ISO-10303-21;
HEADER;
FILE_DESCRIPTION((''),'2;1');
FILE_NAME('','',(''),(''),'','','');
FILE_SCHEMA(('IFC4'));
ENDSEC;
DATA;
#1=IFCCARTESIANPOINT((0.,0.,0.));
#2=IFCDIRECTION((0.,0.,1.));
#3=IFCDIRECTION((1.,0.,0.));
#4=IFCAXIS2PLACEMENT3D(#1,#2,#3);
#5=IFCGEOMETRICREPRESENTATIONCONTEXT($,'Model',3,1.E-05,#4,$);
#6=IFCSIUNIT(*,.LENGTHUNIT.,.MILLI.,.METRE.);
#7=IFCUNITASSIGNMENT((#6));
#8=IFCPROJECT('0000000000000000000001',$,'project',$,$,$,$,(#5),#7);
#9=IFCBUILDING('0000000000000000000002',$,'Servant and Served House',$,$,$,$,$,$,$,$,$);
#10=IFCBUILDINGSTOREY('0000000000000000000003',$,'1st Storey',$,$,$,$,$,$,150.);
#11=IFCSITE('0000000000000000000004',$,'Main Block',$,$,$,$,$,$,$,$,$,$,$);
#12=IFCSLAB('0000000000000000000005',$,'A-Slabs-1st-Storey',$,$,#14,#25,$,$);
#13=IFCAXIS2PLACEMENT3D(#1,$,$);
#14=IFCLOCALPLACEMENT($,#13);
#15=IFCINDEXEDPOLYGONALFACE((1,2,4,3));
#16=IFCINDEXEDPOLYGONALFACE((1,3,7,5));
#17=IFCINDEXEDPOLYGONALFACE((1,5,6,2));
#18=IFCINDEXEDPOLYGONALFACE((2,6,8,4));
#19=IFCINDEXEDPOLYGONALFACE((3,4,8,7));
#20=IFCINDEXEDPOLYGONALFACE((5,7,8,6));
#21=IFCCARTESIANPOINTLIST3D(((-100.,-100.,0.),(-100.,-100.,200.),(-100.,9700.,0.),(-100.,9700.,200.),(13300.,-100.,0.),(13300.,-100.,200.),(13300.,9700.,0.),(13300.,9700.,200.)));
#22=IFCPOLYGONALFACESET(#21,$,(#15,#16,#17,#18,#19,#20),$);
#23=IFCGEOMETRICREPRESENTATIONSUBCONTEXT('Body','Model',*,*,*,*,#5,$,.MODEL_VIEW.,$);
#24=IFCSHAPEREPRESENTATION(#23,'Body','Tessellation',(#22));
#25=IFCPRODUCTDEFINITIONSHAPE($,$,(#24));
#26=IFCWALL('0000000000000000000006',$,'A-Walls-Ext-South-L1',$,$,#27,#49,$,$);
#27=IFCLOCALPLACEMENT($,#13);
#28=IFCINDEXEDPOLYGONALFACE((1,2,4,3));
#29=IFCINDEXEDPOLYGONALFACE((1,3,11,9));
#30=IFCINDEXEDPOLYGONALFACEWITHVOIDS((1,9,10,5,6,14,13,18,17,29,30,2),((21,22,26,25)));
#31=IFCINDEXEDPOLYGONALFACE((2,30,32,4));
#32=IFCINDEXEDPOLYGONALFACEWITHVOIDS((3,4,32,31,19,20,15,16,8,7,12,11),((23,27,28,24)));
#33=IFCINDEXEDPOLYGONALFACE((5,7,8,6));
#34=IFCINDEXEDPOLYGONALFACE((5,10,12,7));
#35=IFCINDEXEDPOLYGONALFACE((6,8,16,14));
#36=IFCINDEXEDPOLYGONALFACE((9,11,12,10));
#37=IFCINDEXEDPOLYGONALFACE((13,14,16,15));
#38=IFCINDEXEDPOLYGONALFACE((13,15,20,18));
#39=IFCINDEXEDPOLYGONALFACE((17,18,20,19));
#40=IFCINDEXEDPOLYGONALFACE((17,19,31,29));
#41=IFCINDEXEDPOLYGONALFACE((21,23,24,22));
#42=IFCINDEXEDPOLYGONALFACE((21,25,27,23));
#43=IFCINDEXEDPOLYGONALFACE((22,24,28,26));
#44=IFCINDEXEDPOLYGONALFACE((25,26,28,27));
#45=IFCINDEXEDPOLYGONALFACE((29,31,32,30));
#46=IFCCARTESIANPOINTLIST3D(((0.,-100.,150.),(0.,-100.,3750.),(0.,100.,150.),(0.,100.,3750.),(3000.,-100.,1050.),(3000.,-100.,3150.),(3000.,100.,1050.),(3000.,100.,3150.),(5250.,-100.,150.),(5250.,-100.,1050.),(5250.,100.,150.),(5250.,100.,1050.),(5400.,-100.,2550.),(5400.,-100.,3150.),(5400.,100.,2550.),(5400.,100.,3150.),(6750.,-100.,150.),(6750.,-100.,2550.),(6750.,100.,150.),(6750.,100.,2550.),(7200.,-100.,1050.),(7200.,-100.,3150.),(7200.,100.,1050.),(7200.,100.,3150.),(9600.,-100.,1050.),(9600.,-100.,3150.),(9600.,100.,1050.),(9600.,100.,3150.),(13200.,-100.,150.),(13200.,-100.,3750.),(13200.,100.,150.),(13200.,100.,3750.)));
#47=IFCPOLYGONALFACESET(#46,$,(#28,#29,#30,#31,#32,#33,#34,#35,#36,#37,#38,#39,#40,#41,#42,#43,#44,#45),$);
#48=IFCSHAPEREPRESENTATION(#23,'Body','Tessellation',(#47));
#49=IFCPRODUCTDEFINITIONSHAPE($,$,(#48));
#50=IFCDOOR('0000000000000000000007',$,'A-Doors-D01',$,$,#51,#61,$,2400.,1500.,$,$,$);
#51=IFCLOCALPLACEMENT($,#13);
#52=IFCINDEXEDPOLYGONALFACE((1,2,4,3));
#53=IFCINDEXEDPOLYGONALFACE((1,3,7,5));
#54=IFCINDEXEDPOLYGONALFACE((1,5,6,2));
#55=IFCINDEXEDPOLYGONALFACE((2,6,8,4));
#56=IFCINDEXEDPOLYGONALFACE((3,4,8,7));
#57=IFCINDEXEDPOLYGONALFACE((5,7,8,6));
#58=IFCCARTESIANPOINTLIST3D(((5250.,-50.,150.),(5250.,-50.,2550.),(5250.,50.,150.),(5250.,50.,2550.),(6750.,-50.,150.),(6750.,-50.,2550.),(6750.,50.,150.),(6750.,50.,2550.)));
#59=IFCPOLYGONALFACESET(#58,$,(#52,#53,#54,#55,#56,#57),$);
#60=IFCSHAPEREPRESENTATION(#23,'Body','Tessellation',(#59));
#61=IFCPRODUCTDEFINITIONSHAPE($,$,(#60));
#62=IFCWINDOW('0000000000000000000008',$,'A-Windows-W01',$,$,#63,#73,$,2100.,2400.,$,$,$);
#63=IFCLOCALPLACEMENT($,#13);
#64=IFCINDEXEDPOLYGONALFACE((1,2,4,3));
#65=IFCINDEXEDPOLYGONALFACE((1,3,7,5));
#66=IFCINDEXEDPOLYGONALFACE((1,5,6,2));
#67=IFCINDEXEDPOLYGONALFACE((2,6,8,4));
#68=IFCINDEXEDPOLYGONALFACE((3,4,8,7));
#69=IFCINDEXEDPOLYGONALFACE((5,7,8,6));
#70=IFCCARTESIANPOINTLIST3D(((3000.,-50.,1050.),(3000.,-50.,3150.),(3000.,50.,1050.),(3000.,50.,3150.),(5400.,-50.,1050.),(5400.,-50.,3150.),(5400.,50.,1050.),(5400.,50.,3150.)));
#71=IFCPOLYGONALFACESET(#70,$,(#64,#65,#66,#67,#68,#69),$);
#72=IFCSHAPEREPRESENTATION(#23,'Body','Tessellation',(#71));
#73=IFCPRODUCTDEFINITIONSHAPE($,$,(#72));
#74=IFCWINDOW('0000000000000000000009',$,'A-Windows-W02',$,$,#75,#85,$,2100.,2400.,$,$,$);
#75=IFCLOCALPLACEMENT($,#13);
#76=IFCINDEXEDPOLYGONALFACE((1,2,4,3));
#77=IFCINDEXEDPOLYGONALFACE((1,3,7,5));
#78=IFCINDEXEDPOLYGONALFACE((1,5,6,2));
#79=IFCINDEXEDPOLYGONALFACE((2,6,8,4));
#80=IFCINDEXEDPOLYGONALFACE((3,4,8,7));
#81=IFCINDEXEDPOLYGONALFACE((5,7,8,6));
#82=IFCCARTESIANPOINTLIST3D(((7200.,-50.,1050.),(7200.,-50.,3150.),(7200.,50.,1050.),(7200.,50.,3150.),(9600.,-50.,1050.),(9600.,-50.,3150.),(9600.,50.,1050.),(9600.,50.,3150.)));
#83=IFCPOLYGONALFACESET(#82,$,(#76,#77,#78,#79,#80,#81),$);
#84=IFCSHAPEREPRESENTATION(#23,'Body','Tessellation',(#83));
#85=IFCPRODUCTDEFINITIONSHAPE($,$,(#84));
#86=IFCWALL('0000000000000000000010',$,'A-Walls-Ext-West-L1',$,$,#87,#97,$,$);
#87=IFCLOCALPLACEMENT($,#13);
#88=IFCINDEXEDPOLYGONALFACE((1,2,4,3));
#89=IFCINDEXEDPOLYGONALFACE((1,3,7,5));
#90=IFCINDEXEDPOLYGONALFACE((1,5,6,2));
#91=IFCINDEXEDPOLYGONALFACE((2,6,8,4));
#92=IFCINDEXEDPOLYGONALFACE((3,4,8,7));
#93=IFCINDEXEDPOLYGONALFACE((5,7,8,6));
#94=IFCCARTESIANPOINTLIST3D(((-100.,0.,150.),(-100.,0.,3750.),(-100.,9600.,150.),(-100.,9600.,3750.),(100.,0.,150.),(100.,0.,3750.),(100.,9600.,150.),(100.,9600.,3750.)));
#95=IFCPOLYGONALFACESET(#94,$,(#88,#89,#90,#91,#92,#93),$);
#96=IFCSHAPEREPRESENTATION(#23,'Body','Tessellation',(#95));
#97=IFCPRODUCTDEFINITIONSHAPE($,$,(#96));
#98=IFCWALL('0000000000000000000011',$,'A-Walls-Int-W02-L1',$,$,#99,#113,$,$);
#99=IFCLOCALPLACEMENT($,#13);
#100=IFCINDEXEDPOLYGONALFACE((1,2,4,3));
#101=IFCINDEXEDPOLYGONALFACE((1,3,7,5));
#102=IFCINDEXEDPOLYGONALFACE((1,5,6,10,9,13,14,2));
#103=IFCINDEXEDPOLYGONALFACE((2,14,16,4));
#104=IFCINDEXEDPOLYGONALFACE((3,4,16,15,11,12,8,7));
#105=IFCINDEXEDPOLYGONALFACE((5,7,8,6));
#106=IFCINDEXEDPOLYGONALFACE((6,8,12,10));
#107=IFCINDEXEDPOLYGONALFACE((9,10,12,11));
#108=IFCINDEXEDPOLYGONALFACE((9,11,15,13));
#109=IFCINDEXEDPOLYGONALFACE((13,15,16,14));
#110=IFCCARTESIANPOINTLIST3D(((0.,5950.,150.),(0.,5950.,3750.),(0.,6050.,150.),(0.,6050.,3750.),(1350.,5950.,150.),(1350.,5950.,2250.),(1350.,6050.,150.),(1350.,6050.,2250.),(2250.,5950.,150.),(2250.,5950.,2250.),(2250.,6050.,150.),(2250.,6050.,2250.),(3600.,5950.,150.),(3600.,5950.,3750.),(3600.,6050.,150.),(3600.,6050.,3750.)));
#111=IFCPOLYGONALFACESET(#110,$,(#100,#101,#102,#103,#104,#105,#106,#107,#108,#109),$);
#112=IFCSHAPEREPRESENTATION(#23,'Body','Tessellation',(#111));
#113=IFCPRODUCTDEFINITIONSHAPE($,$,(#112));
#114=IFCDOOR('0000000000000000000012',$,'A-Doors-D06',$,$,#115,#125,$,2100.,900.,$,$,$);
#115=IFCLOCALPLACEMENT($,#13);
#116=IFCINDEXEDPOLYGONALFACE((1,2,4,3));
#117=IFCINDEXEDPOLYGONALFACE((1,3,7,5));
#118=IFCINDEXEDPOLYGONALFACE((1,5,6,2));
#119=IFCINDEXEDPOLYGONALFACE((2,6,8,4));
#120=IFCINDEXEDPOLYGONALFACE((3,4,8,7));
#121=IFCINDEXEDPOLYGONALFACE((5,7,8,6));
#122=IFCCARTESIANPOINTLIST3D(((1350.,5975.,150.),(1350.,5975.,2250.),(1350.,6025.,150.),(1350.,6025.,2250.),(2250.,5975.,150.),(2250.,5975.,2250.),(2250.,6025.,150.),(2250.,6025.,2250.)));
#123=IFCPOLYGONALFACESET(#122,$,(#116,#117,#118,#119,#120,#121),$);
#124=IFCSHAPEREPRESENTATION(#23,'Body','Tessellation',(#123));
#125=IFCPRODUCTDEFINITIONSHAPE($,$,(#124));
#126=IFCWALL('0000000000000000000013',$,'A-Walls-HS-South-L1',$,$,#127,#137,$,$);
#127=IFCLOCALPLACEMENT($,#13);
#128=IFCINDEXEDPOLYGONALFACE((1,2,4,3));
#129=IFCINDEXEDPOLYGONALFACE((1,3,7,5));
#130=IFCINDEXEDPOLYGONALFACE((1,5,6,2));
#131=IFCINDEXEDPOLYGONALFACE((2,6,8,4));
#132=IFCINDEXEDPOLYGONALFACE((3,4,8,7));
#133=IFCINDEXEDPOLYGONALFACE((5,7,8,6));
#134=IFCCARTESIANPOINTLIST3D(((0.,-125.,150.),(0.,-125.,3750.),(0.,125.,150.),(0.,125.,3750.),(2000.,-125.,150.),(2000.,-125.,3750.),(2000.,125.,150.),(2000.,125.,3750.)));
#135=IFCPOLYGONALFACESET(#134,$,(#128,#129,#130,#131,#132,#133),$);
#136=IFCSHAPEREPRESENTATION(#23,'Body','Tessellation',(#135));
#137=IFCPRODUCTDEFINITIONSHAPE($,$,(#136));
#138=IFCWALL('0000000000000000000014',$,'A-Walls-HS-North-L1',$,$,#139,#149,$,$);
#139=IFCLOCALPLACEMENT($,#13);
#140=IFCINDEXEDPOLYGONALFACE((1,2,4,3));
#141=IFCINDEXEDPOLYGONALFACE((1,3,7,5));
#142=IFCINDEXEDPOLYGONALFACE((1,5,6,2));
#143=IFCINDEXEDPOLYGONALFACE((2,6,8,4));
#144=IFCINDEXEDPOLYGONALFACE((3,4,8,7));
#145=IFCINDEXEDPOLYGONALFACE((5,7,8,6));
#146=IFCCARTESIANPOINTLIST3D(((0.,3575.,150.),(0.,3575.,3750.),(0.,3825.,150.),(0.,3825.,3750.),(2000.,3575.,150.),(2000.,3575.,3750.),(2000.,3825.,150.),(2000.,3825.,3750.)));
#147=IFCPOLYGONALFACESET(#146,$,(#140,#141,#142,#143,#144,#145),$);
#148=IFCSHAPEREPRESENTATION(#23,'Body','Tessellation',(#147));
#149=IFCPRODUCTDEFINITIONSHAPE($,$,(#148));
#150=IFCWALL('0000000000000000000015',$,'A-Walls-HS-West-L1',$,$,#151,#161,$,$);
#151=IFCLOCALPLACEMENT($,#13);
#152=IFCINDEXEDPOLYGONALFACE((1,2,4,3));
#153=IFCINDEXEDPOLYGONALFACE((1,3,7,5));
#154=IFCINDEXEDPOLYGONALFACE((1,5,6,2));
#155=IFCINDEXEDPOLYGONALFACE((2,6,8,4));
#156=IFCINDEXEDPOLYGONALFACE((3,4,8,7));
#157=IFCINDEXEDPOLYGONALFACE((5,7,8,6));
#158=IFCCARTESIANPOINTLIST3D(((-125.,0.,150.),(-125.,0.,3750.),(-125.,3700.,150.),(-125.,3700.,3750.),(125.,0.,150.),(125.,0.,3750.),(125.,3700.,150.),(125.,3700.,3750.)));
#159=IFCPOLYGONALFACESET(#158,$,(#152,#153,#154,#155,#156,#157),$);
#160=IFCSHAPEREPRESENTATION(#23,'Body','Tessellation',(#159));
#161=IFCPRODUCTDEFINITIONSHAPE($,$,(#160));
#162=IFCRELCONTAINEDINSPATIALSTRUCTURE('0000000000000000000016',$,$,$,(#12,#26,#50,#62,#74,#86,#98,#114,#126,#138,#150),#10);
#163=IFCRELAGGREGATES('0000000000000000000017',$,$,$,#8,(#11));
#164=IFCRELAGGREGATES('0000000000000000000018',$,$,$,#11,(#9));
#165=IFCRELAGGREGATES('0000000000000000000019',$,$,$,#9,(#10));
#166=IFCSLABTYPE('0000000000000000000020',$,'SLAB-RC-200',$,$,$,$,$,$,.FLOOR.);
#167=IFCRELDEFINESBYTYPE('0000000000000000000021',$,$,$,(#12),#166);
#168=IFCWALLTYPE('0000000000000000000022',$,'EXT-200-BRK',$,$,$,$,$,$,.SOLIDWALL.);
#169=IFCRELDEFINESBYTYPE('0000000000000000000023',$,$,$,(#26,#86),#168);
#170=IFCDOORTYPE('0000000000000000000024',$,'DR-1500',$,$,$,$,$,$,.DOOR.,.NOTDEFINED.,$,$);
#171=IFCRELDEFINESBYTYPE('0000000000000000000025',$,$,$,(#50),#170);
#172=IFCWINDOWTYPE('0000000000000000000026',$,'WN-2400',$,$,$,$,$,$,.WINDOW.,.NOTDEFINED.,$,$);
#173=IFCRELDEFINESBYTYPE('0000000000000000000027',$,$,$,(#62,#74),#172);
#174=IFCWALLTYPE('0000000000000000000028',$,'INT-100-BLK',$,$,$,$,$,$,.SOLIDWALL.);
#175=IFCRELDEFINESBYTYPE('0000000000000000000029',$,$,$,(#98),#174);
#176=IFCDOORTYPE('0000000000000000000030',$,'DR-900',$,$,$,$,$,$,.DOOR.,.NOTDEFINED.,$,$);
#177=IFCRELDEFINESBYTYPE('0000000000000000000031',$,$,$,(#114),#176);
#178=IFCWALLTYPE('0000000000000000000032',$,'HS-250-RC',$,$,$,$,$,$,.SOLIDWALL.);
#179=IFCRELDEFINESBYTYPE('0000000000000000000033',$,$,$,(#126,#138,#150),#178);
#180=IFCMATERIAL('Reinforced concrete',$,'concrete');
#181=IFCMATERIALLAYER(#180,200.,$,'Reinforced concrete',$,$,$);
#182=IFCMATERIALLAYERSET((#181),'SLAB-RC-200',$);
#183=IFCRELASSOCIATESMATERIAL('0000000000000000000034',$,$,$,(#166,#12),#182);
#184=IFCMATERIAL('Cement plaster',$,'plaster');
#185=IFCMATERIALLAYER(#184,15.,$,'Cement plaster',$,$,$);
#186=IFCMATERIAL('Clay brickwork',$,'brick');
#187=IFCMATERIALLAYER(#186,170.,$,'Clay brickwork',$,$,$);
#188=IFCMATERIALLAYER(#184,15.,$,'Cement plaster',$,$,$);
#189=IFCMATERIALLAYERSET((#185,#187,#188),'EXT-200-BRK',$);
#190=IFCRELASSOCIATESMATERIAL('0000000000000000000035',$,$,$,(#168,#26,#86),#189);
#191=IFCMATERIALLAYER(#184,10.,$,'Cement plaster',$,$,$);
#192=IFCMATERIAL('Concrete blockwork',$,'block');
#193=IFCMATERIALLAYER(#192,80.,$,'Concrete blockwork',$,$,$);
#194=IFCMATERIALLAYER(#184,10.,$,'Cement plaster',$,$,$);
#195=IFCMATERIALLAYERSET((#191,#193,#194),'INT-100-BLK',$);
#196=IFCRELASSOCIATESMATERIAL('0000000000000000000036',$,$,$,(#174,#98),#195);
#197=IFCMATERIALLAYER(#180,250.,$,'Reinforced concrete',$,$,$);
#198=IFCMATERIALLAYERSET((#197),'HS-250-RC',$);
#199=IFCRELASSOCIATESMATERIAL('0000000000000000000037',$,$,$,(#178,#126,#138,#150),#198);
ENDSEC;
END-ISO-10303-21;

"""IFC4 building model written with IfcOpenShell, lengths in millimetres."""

from ifc_helpers import new_model, si_unit, frame, origin_with_axes, place, context, subcontext, project, spatial, indexed_curve, outline, extrude, material, layer, layer_set, layer_usage, type_object, element, fill, save


model = new_model("IFC4")

# Units and contexts
model_context = context("Model", 3, precision=1e-05, world=origin_with_axes())
body_context = subcontext(model_context, "Body", "Model", "MODEL_VIEW")
ifc_project = project(units=[si_unit("LENGTHUNIT", "METRE", prefix="MILLI")], contexts=[model_context])

# Site, building, storey
site = spatial("IfcSite", under=ifc_project, Name="Main Block")
building = spatial("IfcBuilding", under=site, Name="Servant and Served House")
storey = spatial("IfcBuildingStorey", under=building, Name="1st Storey", Elevation=150.0)

# Slab
ifc_material_1 = material(Name="Reinforced concrete", Category="concrete")
ifc_layer_1 = layer(ifc_material_1, 200.0, Name="Reinforced concrete")
ifc_layer_set_1 = layer_set([ifc_layer_1], Name="SLAB-RC-200")
ifc_layer_usage_1 = layer_usage(ifc_layer_set_1, "AXIS3", "POSITIVE", 0.0)
slab_type = type_object("IfcSlabType", Name="SLAB-RC-200", PredefinedType="FLOOR", material=ifc_layer_set_1)
slab_placement = place(None, origin_with_axes())
element("IfcSlab", 1, at=slab_placement, inside=storey, type_object=slab_type, material=ifc_layer_usage_1, Name="A-Slabs-1st-Storey", context=body_context, shape_type="SweptSolid", body=[
    extrude(outline(indexed_curve([(-100.0, -100.0), (13300.0, -100.0), (13300.0, 9700.0), (-100.0, 9700.0)])), None, (0.0, 0.0, 1.0), 200.0),
])

# Wall, openings, door, windows
ifc_material_2 = material(Name="Cement plaster", Category="plaster")
ifc_layer_2 = layer(ifc_material_2, 15.0, Name="Cement plaster")
ifc_material_3 = material(Name="Clay brickwork", Category="brick")
ifc_layer_3 = layer(ifc_material_3, 170.0, Name="Clay brickwork")
ifc_layer_4 = layer(ifc_material_2, 15.0, Name="Cement plaster")
ifc_layer_set_2 = layer_set([ifc_layer_2, ifc_layer_3, ifc_layer_4], Name="EXT-200-BRK")
ifc_layer_usage_2 = layer_usage(ifc_layer_set_2, "AXIS2", "POSITIVE", 0.0)
wall_type_1 = type_object("IfcWallType", Name="EXT-200-BRK", PredefinedType="SOLIDWALL", material=ifc_layer_set_2)
wall_1_placement = place(None, frame((0.0, -100.0, 150.0), z_axis=(0.0, 0.0, 1.0), x_axis=(1.0, 0.0, 0.0)))
wall_1 = element("IfcWall", 2, at=wall_1_placement, inside=storey, type_object=wall_type_1, material=ifc_layer_usage_2, Name="A-Walls-Ext-South-L1", context=body_context, shape_type="SweptSolid", body=[
    extrude(outline(indexed_curve([(0.0, 0.0), (0.0, 200.0), (13200.0, 200.0), (13200.0, 0.0), (0.0, 0.0)], self_intersect=False)), origin_with_axes(), (0.0, 0.0, 1.0), 3600.0),
])
opening_1_placement = place(wall_1_placement, frame((6000.0, 100.0, 0.0), z_axis=(0.0, 0.0, 1.0), x_axis=(1.0, 0.0, 0.0)))
opening_1 = element("IfcOpeningElement", 3, at=opening_1_placement, cuts=wall_1, PredefinedType="OPENING", context=body_context, shape_type="SweptSolid", body=[
    extrude(outline(indexed_curve([(-750.0, -150.0), (750.0, -150.0), (750.0, 150.0), (-750.0, 150.0)])), None, (0.0, 0.0, 1.0), 2400.0),
])
opening_2_placement = place(wall_1_placement, frame((4200.0, 100.0, 900.0), z_axis=(0.0, 0.0, 1.0), x_axis=(1.0, 0.0, 0.0)))
opening_2 = element("IfcOpeningElement", 4, at=opening_2_placement, cuts=wall_1, PredefinedType="OPENING", context=body_context, shape_type="SweptSolid", body=[
    extrude(outline(indexed_curve([(-1200.0, -150.0), (1200.0, -150.0), (1200.0, 150.0), (-1200.0, 150.0)])), None, (0.0, 0.0, 1.0), 2100.0),
])
opening_3_placement = place(wall_1_placement, frame((8400.0, 100.0, 900.0), z_axis=(0.0, 0.0, 1.0), x_axis=(1.0, 0.0, 0.0)))
opening_3 = element("IfcOpeningElement", 5, at=opening_3_placement, cuts=wall_1, PredefinedType="OPENING", context=body_context, shape_type="SweptSolid", body=[
    extrude(outline(indexed_curve([(-1200.0, -150.0), (1200.0, -150.0), (1200.0, 150.0), (-1200.0, 150.0)])), None, (0.0, 0.0, 1.0), 2100.0),
])
door_type_1 = type_object("IfcDoorType", Name="DR-1500", OperationType="NOTDEFINED", PredefinedType="DOOR")
door_1_placement = place(None, frame((6000.0, 0.0, 150.0), z_axis=(0.0, 0.0, 1.0), x_axis=(1.0, 0.0, 0.0)))
door_1 = element("IfcDoor", 6, at=door_1_placement, inside=storey, type_object=door_type_1, Name="A-Doors-D01", OverallHeight=2400.0, OverallWidth=1500.0, context=body_context, shape_type="SweptSolid", body=[
    extrude(outline(indexed_curve([(-750.0, -50.0), (750.0, -50.0), (750.0, 50.0), (-750.0, 50.0)])), None, (0.0, 0.0, 1.0), 2400.0),
])
fill(opening_1, door_1)
window_type = type_object("IfcWindowType", Name="WN-2400", PartitioningType="NOTDEFINED", PredefinedType="WINDOW")
window_1_placement = place(None, frame((4200.0, 0.0, 1050.0), z_axis=(0.0, 0.0, 1.0), x_axis=(1.0, 0.0, 0.0)))
window_1 = element("IfcWindow", 7, at=window_1_placement, inside=storey, type_object=window_type, Name="A-Windows-W01", OverallHeight=2100.0, OverallWidth=2400.0, context=body_context, shape_type="SweptSolid", body=[
    extrude(outline(indexed_curve([(-1200.0, -50.0), (1200.0, -50.0), (1200.0, 50.0), (-1200.0, 50.0)])), None, (0.0, 0.0, 1.0), 2100.0),
])
fill(opening_2, window_1)
window_2_placement = place(None, frame((8400.0, 0.0, 1050.0), z_axis=(0.0, 0.0, 1.0), x_axis=(1.0, 0.0, 0.0)))
window_2 = element("IfcWindow", 8, at=window_2_placement, inside=storey, type_object=window_type, Name="A-Windows-W02", OverallHeight=2100.0, OverallWidth=2400.0, context=body_context, shape_type="SweptSolid", body=[
    extrude(outline(indexed_curve([(-1200.0, -50.0), (1200.0, -50.0), (1200.0, 50.0), (-1200.0, 50.0)])), None, (0.0, 0.0, 1.0), 2100.0),
])
fill(opening_3, window_2)

# Wall
ifc_layer_usage_3 = layer_usage(ifc_layer_set_2, "AXIS2", "POSITIVE", 0.0)
wall_2_placement = place(None, frame((-100.0, 9600.0, 150.0), z_axis=(0.0, 0.0, 1.0), x_axis=(0.0, -1.0, 0.0)))
element("IfcWall", 9, at=wall_2_placement, inside=storey, type_object=wall_type_1, material=ifc_layer_usage_3, Name="A-Walls-Ext-West-L1", context=body_context, shape_type="SweptSolid", body=[
    extrude(outline(indexed_curve([(0.0, 0.0), (0.0, 200.0), (9600.0, 200.0), (9600.0, 0.0), (0.0, 0.0)], self_intersect=False)), origin_with_axes(), (0.0, 0.0, 1.0), 3600.0),
])

# Wall, opening, door
ifc_layer_5 = layer(ifc_material_2, 10.0, Name="Cement plaster")
ifc_material_4 = material(Name="Concrete blockwork", Category="block")
ifc_layer_6 = layer(ifc_material_4, 80.0, Name="Concrete blockwork")
ifc_layer_7 = layer(ifc_material_2, 10.0, Name="Cement plaster")
ifc_layer_set_3 = layer_set([ifc_layer_5, ifc_layer_6, ifc_layer_7], Name="INT-100-BLK")
ifc_layer_usage_4 = layer_usage(ifc_layer_set_3, "AXIS2", "POSITIVE", 0.0)
wall_type_2 = type_object("IfcWallType", Name="INT-100-BLK", PredefinedType="SOLIDWALL", material=ifc_layer_set_3)
wall_3_placement = place(None, frame((0.0, 5950.0, 150.0), z_axis=(0.0, 0.0, 1.0), x_axis=(1.0, 0.0, 0.0)))
wall_3 = element("IfcWall", 10, at=wall_3_placement, inside=storey, type_object=wall_type_2, material=ifc_layer_usage_4, Name="A-Walls-Int-W02-L1", context=body_context, shape_type="SweptSolid", body=[
    extrude(outline(indexed_curve([(0.0, 0.0), (0.0, 100.0), (3600.0, 100.0), (3600.0, 0.0), (0.0, 0.0)], self_intersect=False)), origin_with_axes(), (0.0, 0.0, 1.0), 3600.0),
])
opening_4_placement = place(wall_3_placement, frame((1800.0, 50.0, 0.0), z_axis=(0.0, 0.0, 1.0), x_axis=(1.0, 0.0, 0.0)))
opening_4 = element("IfcOpeningElement", 11, at=opening_4_placement, cuts=wall_3, PredefinedType="OPENING", context=body_context, shape_type="SweptSolid", body=[
    extrude(outline(indexed_curve([(-450.0, -100.0), (450.0, -100.0), (450.0, 100.0), (-450.0, 100.0)])), None, (0.0, 0.0, 1.0), 2100.0),
])
door_type_2 = type_object("IfcDoorType", Name="DR-900", OperationType="NOTDEFINED", PredefinedType="DOOR")
door_2_placement = place(None, frame((1800.0, 6000.0, 150.0), z_axis=(0.0, 0.0, 1.0), x_axis=(1.0, 0.0, 0.0)))
door_2 = element("IfcDoor", 12, at=door_2_placement, inside=storey, type_object=door_type_2, Name="A-Doors-D06", OverallHeight=2100.0, OverallWidth=900.0, context=body_context, shape_type="SweptSolid", body=[
    extrude(outline(indexed_curve([(-450.0, -25.0), (450.0, -25.0), (450.0, 25.0), (-450.0, 25.0)])), None, (0.0, 0.0, 1.0), 2100.0),
])
fill(opening_4, door_2)

# Walls
ifc_layer_8 = layer(ifc_material_1, 250.0, Name="Reinforced concrete")
ifc_layer_set_4 = layer_set([ifc_layer_8], Name="HS-250-RC")
ifc_layer_usage_5 = layer_usage(ifc_layer_set_4, "AXIS2", "POSITIVE", 0.0)
wall_type_3 = type_object("IfcWallType", Name="HS-250-RC", PredefinedType="SOLIDWALL", material=ifc_layer_set_4)
wall_4_placement = place(None, frame((0.0, -125.0, 150.0), z_axis=(0.0, 0.0, 1.0), x_axis=(1.0, 0.0, 0.0)))
element("IfcWall", 13, at=wall_4_placement, inside=storey, type_object=wall_type_3, material=ifc_layer_usage_5, Name="A-Walls-HS-South-L1", context=body_context, shape_type="SweptSolid", body=[
    extrude(outline(indexed_curve([(0.0, 0.0), (0.0, 250.0), (2000.0, 250.0), (2000.0, 0.0), (0.0, 0.0)], self_intersect=False)), origin_with_axes(), (0.0, 0.0, 1.0), 3600.0),
])
ifc_layer_usage_6 = layer_usage(ifc_layer_set_4, "AXIS2", "POSITIVE", 0.0)
wall_5_placement = place(None, frame((2000.0, 3825.0, 150.0), z_axis=(0.0, 0.0, 1.0), x_axis=(-1.0, 0.0, 0.0)))
element("IfcWall", 14, at=wall_5_placement, inside=storey, type_object=wall_type_3, material=ifc_layer_usage_6, Name="A-Walls-HS-North-L1", context=body_context, shape_type="SweptSolid", body=[
    extrude(outline(indexed_curve([(0.0, 0.0), (0.0, 250.0), (2000.0, 250.0), (2000.0, 0.0), (0.0, 0.0)], self_intersect=False)), origin_with_axes(), (0.0, 0.0, 1.0), 3600.0),
])
ifc_layer_usage_7 = layer_usage(ifc_layer_set_4, "AXIS2", "POSITIVE", 0.0)
wall_6_placement = place(None, frame((-125.0, 3700.0, 150.0), z_axis=(0.0, 0.0, 1.0), x_axis=(0.0, -1.0, 0.0)))
element("IfcWall", 15, at=wall_6_placement, inside=storey, type_object=wall_type_3, material=ifc_layer_usage_7, Name="A-Walls-HS-West-L1", context=body_context, shape_type="SweptSolid", body=[
    extrude(outline(indexed_curve([(0.0, 0.0), (0.0, 250.0), (3700.0, 250.0), (3700.0, 0.0), (0.0, 0.0)], self_intersect=False)), origin_with_axes(), (0.0, 0.0, 1.0), 3600.0),
])

save(model, "model.ifc")
